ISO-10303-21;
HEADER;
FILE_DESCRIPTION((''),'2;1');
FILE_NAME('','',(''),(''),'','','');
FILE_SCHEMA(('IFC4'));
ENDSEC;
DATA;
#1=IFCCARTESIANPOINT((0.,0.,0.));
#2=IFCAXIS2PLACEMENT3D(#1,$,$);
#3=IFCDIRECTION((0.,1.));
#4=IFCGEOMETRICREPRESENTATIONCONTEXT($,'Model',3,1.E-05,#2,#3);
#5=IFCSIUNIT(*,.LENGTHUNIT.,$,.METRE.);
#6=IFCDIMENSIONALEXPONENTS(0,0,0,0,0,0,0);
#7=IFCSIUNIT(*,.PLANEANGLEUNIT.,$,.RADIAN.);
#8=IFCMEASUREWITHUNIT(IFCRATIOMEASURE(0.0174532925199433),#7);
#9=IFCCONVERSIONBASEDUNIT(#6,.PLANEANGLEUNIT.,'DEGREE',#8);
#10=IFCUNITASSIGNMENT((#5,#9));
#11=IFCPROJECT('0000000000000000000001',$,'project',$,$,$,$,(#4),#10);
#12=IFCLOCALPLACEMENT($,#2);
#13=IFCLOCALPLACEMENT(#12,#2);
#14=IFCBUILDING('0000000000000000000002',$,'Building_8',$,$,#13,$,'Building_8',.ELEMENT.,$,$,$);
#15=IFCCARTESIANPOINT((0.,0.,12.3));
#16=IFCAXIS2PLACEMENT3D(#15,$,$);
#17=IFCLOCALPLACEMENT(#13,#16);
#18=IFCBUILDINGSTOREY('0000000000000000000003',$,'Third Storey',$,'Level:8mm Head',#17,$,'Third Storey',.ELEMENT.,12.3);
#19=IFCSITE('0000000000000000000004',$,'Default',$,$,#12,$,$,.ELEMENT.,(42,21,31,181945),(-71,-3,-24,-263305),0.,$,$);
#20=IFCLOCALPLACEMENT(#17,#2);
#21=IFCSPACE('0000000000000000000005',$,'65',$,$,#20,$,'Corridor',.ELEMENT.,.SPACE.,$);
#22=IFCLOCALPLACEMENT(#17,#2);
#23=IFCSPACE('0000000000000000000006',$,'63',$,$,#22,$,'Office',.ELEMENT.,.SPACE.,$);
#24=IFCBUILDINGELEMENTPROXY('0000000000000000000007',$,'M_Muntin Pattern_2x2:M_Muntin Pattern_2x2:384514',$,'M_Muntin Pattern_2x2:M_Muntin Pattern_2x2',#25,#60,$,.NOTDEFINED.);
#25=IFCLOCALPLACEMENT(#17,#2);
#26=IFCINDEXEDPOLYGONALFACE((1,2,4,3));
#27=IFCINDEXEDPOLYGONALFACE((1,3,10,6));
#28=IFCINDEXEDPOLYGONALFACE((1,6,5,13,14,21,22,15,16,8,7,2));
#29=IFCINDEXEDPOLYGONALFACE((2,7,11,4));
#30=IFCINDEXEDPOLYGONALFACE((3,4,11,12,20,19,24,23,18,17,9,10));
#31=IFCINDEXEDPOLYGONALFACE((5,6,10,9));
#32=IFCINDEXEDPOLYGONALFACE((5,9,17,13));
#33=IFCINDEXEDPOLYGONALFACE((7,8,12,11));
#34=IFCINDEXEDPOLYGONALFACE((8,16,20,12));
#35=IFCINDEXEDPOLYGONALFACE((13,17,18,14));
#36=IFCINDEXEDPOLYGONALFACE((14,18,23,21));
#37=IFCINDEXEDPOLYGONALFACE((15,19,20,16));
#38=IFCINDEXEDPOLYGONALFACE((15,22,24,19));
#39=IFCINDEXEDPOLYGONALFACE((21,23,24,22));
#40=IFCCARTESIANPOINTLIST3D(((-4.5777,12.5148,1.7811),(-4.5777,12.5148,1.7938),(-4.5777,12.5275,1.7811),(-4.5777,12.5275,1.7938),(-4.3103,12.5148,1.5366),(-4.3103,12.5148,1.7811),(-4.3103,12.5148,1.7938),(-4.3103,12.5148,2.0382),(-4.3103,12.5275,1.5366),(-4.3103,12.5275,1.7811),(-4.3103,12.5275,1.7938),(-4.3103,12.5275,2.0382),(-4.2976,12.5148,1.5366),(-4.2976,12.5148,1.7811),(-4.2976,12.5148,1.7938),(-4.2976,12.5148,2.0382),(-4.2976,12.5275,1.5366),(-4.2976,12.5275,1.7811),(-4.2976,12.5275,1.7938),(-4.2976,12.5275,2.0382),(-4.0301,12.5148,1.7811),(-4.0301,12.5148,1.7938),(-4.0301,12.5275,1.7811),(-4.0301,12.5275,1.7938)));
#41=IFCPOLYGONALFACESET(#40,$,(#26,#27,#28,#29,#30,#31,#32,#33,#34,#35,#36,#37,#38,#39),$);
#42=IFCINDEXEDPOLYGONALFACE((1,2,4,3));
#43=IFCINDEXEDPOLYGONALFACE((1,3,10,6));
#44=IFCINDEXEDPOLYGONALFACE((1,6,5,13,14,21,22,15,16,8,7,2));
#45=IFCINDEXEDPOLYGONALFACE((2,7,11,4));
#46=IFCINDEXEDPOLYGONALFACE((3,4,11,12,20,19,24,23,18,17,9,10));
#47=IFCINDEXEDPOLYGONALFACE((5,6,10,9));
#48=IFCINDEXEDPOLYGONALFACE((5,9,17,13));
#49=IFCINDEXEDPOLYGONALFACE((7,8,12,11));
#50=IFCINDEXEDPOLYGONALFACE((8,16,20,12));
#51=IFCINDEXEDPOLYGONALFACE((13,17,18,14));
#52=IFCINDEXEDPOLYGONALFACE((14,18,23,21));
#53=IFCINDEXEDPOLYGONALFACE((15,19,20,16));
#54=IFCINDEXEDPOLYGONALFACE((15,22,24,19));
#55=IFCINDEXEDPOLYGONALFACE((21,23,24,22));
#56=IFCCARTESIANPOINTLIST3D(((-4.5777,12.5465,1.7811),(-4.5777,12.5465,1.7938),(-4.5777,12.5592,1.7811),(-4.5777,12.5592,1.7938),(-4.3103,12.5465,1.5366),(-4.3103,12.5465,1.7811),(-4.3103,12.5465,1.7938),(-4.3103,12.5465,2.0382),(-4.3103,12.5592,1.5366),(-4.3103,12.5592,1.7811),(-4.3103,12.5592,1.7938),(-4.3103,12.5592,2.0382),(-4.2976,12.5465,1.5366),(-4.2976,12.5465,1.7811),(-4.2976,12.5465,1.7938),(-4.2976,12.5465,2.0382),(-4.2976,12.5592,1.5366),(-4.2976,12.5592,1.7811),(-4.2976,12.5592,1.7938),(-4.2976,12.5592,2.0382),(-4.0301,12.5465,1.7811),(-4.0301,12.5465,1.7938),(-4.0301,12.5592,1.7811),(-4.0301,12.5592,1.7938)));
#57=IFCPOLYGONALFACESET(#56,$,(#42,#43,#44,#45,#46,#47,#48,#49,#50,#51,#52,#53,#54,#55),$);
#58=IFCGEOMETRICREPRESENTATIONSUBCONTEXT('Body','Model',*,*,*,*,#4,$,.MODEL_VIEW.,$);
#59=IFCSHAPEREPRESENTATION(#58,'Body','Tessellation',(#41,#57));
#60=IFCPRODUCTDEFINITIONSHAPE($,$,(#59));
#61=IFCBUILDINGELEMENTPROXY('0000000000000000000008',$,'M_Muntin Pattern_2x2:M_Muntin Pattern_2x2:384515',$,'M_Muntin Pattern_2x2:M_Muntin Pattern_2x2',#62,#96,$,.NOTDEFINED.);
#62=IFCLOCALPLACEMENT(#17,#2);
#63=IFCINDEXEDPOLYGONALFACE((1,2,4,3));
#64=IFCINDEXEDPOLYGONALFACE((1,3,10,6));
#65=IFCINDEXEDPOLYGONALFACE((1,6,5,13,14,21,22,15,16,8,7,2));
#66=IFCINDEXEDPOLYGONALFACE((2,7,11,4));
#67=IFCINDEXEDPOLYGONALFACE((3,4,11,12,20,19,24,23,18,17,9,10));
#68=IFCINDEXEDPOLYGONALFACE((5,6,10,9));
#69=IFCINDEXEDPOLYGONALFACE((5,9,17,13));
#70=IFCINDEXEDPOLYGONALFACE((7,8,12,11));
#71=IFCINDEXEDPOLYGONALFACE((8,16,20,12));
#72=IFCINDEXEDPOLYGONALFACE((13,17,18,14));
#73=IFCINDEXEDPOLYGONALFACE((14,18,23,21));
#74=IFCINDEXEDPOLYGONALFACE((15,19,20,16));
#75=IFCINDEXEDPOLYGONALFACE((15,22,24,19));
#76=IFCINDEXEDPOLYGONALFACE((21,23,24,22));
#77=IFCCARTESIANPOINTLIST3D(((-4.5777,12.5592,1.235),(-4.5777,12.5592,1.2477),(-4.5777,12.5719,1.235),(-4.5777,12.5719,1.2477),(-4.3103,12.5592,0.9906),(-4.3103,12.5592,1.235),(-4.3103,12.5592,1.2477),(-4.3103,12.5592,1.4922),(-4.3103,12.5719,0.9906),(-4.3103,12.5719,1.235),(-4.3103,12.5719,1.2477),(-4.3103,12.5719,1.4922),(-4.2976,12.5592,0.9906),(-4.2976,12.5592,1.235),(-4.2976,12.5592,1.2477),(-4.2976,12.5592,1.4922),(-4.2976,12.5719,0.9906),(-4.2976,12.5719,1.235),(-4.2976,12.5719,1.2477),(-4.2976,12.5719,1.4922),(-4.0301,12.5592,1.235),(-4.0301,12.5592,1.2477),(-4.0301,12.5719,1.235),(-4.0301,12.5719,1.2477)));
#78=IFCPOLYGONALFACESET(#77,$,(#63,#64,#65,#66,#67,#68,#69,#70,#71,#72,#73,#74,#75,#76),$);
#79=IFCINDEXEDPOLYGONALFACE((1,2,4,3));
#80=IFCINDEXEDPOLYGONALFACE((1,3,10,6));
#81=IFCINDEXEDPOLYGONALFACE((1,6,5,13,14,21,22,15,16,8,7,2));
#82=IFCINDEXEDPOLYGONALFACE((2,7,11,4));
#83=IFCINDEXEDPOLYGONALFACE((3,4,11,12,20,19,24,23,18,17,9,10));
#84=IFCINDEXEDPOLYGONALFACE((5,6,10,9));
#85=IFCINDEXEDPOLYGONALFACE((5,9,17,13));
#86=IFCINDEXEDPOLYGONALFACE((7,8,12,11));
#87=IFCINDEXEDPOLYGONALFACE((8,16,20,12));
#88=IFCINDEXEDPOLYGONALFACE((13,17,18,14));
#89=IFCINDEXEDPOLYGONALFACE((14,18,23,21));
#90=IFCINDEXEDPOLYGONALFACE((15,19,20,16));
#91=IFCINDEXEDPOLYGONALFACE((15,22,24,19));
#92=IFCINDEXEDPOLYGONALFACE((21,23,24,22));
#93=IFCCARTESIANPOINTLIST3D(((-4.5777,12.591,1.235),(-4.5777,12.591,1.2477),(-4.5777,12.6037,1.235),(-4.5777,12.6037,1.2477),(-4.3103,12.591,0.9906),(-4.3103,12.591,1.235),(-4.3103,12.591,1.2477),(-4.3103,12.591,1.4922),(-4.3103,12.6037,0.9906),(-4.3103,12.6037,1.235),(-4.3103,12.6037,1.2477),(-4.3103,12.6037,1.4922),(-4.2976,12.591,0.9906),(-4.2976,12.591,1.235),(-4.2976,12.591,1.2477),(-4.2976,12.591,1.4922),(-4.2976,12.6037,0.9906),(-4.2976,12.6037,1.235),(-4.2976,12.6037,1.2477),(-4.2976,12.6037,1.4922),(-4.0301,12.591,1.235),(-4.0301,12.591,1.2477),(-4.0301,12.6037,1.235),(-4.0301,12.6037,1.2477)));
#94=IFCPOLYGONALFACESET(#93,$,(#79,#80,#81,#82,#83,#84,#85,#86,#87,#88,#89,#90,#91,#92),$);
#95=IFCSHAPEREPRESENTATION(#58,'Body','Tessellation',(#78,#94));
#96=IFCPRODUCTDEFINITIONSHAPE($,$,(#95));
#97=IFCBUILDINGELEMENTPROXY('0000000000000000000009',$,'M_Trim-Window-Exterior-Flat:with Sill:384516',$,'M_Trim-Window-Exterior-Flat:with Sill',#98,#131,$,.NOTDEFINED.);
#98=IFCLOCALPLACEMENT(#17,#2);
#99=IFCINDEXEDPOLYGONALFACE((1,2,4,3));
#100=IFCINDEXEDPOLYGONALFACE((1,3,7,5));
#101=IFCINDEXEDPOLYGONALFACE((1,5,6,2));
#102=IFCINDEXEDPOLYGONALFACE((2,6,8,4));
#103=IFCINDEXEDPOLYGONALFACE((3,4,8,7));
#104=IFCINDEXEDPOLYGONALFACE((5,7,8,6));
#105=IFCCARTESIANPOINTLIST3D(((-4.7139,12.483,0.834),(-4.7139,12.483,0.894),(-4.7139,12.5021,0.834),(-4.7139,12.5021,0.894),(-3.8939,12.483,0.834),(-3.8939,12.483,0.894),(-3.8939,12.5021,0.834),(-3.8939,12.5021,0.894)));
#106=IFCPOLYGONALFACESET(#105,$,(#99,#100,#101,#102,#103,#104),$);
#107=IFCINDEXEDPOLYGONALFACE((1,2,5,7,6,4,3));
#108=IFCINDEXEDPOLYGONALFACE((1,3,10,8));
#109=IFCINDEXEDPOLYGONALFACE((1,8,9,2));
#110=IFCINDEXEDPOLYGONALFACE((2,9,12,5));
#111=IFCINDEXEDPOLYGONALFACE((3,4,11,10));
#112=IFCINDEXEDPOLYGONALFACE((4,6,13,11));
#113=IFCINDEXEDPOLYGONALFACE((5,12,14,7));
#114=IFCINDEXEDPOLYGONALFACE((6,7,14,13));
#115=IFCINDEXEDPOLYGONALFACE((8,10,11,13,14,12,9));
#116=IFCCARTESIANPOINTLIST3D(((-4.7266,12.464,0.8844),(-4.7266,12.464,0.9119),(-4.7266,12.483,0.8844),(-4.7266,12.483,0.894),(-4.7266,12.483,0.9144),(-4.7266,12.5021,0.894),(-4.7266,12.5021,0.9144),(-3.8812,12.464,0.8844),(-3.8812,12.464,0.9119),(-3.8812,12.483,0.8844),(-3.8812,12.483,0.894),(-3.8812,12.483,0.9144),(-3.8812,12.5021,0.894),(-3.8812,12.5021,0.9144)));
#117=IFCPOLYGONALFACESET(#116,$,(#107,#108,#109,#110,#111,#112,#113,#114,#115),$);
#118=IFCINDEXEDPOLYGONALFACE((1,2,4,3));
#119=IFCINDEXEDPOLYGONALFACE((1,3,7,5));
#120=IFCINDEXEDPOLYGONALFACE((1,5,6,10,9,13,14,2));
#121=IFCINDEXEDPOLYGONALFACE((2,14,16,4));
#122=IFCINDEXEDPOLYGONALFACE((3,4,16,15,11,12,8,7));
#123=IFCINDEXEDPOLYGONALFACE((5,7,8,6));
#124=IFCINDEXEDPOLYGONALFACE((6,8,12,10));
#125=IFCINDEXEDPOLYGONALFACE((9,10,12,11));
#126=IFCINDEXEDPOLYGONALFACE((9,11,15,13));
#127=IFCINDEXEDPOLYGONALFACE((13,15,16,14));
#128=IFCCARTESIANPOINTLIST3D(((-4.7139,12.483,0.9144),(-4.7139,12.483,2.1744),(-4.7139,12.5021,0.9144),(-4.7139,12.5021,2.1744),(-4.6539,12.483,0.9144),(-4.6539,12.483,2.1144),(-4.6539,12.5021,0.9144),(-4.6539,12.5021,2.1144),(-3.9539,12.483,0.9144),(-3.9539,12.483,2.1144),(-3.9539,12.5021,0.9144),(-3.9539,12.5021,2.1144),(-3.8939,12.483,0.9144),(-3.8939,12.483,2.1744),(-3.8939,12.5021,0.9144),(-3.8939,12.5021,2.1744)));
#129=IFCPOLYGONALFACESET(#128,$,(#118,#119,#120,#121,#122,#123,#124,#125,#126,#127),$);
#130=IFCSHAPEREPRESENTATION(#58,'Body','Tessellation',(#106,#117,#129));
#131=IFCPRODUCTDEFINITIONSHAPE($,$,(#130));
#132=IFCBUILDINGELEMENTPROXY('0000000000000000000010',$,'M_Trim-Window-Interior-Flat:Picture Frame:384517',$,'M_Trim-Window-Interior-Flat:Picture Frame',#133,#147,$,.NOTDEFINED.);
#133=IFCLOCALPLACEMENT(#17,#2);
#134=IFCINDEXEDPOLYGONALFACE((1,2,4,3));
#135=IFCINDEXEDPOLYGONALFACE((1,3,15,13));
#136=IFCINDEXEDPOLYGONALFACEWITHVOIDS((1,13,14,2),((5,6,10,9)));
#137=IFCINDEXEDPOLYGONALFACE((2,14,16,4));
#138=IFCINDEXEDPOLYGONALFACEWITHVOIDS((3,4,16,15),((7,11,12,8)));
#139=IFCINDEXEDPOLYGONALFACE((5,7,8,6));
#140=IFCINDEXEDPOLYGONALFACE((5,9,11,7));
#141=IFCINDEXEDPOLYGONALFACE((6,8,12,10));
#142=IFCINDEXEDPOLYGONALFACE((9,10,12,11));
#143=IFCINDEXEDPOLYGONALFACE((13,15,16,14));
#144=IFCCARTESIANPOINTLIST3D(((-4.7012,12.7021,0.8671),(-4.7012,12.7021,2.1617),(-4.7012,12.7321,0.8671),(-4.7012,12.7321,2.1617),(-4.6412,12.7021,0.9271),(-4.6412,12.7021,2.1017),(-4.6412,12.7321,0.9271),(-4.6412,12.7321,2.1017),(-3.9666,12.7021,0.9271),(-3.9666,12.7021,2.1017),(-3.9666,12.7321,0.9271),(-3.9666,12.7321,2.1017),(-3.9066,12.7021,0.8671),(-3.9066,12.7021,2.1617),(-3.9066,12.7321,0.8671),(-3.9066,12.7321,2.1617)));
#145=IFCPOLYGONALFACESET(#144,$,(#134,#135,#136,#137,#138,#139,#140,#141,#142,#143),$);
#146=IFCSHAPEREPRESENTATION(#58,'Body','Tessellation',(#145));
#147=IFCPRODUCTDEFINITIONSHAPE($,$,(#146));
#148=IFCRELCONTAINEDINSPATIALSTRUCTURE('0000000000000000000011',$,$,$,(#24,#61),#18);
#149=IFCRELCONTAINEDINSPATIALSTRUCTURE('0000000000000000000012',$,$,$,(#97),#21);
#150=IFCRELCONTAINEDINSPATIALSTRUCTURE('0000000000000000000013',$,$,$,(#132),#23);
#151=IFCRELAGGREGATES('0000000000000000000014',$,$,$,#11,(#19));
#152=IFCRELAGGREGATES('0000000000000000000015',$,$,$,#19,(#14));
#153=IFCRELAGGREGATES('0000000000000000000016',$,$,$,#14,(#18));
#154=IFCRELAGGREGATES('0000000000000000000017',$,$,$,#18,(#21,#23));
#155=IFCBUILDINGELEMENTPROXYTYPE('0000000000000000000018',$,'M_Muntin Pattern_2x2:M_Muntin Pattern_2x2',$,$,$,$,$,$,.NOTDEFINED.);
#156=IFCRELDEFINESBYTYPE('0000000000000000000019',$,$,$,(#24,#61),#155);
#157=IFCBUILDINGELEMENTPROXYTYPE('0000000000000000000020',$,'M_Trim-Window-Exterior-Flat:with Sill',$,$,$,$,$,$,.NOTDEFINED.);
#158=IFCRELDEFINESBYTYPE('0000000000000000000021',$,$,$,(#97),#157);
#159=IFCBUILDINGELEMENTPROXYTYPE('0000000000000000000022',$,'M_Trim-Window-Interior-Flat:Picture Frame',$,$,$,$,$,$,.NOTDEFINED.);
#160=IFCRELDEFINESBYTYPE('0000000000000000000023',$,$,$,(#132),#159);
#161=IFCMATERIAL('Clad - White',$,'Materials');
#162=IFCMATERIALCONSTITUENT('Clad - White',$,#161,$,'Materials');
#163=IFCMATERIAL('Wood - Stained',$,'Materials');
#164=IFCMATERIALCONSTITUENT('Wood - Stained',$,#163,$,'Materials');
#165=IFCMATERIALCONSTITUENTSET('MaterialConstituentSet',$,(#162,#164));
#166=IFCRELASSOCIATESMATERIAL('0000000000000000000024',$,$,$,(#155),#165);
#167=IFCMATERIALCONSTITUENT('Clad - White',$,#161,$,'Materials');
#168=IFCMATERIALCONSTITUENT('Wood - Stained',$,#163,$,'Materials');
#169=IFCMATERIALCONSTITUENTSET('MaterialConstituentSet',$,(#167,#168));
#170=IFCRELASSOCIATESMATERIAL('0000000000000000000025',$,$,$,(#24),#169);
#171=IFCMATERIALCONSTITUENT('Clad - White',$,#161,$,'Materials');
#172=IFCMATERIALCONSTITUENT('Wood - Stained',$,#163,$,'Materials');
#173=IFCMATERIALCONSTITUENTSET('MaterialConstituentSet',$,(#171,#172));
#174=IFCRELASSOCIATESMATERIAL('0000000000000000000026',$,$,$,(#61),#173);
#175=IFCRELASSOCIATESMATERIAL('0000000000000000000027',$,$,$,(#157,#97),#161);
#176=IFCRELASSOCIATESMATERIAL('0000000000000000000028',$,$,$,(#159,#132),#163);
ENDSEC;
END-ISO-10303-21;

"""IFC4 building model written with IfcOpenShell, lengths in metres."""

from ifc_helpers import new_model, entity, si_unit, converted_unit, direction, frame, origin, place, context, subcontext, project, spatial, indexed_curve, outline, extrude, source, transform, mapped, material, constituent, constituent_set, type_object, type_shapes, element, save


model = new_model("IFC4")

# Units and contexts
model_context = context("Model", 3, precision=1e-05, world=origin(), true_north=direction((0.0, 1.0)))
body_context = subcontext(model_context, "Body", "Model", "MODEL_VIEW")
ifc_project = project(units=[si_unit("LENGTHUNIT", "METRE"), converted_unit("PLANEANGLEUNIT", "DEGREE", entity("IfcRatioMeasure", 0.0174532925199433), si_unit("PLANEANGLEUNIT", "RADIAN"), dimensions=[0, 0, 0, 0, 0, 0, 0])], contexts=[model_context])

# Site, building, storey
site_placement = place(None, origin())
site = spatial("IfcSite", under=ifc_project, at=site_placement, Name="Default", CompositionType="ELEMENT", RefLatitude=(42, 21, 31, 181945), RefLongitude=(-71, -3, -24, -263305), RefElevation=0.0)
building_placement = place(site_placement, origin())
building = spatial("IfcBuilding", under=site, at=building_placement, Name="Building_8", LongName="Building_8", CompositionType="ELEMENT")
storey_placement = place(building_placement, frame((0.0, 0.0, 12.3)))
storey = spatial("IfcBuildingStorey", under=building, at=storey_placement, Name="Third Storey", ObjectType="Level:8mm Head", LongName="Third Storey", CompositionType="ELEMENT", Elevation=12.3)

# Shared definitions
ifc_material_1 = material(Name="Clad - White", Category="Materials")
ifc_material_2 = material(Name="Wood - Stained", Category="Materials")

# Shared definitions
space_1_placement = place(storey_placement, origin())
space_1 = spatial("IfcSpace", under=storey, at=space_1_placement, Name="65", LongName="Corridor", CompositionType="ELEMENT", PredefinedType="SPACE")

# Building element proxies
ifc_constituent_1 = constituent(ifc_material_1, Name="Clad - White", Category="Materials")
ifc_constituent_2 = constituent(ifc_material_2, Name="Wood - Stained", Category="Materials")
ifc_constituent_set_1 = constituent_set(constituents=[ifc_constituent_1, ifc_constituent_2], Name="MaterialConstituentSet")
ifc_constituent_3 = constituent(ifc_material_1, Name="Clad - White", Category="Materials")
ifc_constituent_4 = constituent(ifc_material_2, Name="Wood - Stained", Category="Materials")
ifc_constituent_set_2 = constituent_set(constituents=[ifc_constituent_3, ifc_constituent_4], Name="MaterialConstituentSet")
building_element_proxy_type_1 = type_object("IfcBuildingElementProxyType", Name="M_Muntin Pattern_2x2:M_Muntin Pattern_2x2", PredefinedType="NOTDEFINED", material=ifc_constituent_set_2)
shared_shape_1 = source(origin(), body_context, "Body", "SweptSolid", [
    extrude(outline(indexed_curve([(0.0064, -0.0064), (0.2508, -0.0064), (0.2508, 0.0063), (0.0064, 0.0063), (0.0064, 0.2738), (-0.0063, 0.2738), (-0.0063, 0.0063), (-0.2508, 0.0063), (-0.2508, -0.0064), (-0.0063, -0.0064), (-0.0063, -0.2738), (0.0064, -0.2738), (0.0064, -0.0064)], self_intersect=False)), frame((0.0, 0.0095, 0.2508), z_axis=(0.0, 1.0, 0.0), x_axis=(0.0, 0.0, 1.0)), (0.0, 0.0, 1.0), 0.0127),
    extrude(outline(indexed_curve([(0.0064, -0.0064), (0.2508, -0.0064), (0.2508, 0.0063), (0.0064, 0.0063), (0.0064, 0.2738), (-0.0063, 0.2738), (-0.0063, 0.0063), (-0.2508, 0.0063), (-0.2508, -0.0064), (-0.0063, -0.0064), (-0.0063, -0.2738), (0.0064, -0.2738), (0.0064, -0.0064)], self_intersect=False)), frame((0.0, -0.0222, 0.2508), z_axis=(0.0, 1.0, 0.0), x_axis=(0.0, 0.0, 1.0)), (0.0, 0.0, 1.0), 0.0127),
])
type_shapes(building_element_proxy_type_1, [shared_shape_1])
proxy_1_placement = place(storey_placement, frame((-4.3039, 12.537, 1.5366), z_axis=(0.0, 0.0, 1.0), x_axis=(-1.0, 0.0, 0.0)))
element("IfcBuildingElementProxy", 1, at=proxy_1_placement, inside=storey, type_object=building_element_proxy_type_1, material=ifc_constituent_set_1, Name="M_Muntin Pattern_2x2:M_Muntin Pattern_2x2:384514", ObjectType="M_Muntin Pattern_2x2:M_Muntin Pattern_2x2", PredefinedType="NOTDEFINED", context=body_context, shape_type="MappedRepresentation", body=[
    mapped(shared_shape_1, transform((0.0, 0.0, 0.0), scale=1.0)),
])
ifc_constituent_5 = constituent(ifc_material_1, Name="Clad - White", Category="Materials")
ifc_constituent_6 = constituent(ifc_material_2, Name="Wood - Stained", Category="Materials")
ifc_constituent_set_3 = constituent_set(constituents=[ifc_constituent_5, ifc_constituent_6], Name="MaterialConstituentSet")
proxy_2_placement = place(storey_placement, frame((-4.3039, 12.5814, 0.9906), z_axis=(0.0, 0.0, 1.0), x_axis=(-1.0, 0.0, 0.0)))
element("IfcBuildingElementProxy", 2, at=proxy_2_placement, inside=storey, type_object=building_element_proxy_type_1, material=ifc_constituent_set_3, Name="M_Muntin Pattern_2x2:M_Muntin Pattern_2x2:384515", ObjectType="M_Muntin Pattern_2x2:M_Muntin Pattern_2x2", PredefinedType="NOTDEFINED", context=body_context, shape_type="MappedRepresentation", body=[
    mapped(shared_shape_1, transform((0.0, 0.0, 0.0), scale=1.0)),
])
building_element_proxy_type_2 = type_object("IfcBuildingElementProxyType", Name="M_Trim-Window-Exterior-Flat:with Sill", PredefinedType="NOTDEFINED", material=ifc_material_1)
shared_shape_2 = source(origin(), body_context, "Body", "SweptSolid", [
    extrude(outline(indexed_curve([(-0.41, -0.03), (0.41, -0.03), (0.41, 0.03), (-0.41, 0.03), (-0.41, -0.03)], self_intersect=False)), frame((0.0, -1.2504, 0.0), z_axis=(0.0, 0.0, 1.0), x_axis=(-1.0, 0.0, 0.0)), (0.0, 0.0, 1.0), 0.0191),
    extrude(outline(indexed_curve([(-0.019, -0.0152), (0.0, -0.0152), (0.0, -0.0057), (0.019, -0.0057), (0.019, 0.0148), (0.0, 0.0148), (-0.019, 0.0123), (-0.019, -0.0152)], self_intersect=False)), frame((-0.4227, -1.2148, 0.019), z_axis=(1.0, 0.0, 0.0), x_axis=(0.0, 0.0, -1.0)), (0.0, 0.0, 1.0), 0.8454),
    extrude(outline(indexed_curve([(-0.645, -0.41), (0.615, -0.41), (0.615, -0.35), (-0.585, -0.35), (-0.585, 0.35), (0.615, 0.35), (0.615, 0.41), (-0.645, 0.41), (-0.645, -0.41)], self_intersect=False)), frame((0.0, -0.585, 0.0), z_axis=(0.0, 0.0, 1.0), x_axis=(0.0, -1.0, 0.0)), (0.0, 0.0, 1.0), 0.0191),
])
type_shapes(building_element_proxy_type_2, [shared_shape_2])
proxy_3_placement = place(space_1_placement, frame((-4.3039, 12.5021, 2.1144), z_axis=(0.0, -1.0, 0.0), x_axis=(1.0, 0.0, 0.0)))
element("IfcBuildingElementProxy", 3, at=proxy_3_placement, inside=space_1, type_object=building_element_proxy_type_2, material=ifc_material_1, Name="M_Trim-Window-Exterior-Flat:with Sill:384516", ObjectType="M_Trim-Window-Exterior-Flat:with Sill", PredefinedType="NOTDEFINED", context=body_context, shape_type="MappedRepresentation", body=[
    mapped(shared_shape_2, transform((0.0, 0.0, 0.0), scale=1.0)),
])

# Shared definitions
space_2_placement = place(storey_placement, origin())
space_2 = spatial("IfcSpace", under=storey, at=space_2_placement, Name="63", LongName="Office", CompositionType="ELEMENT", PredefinedType="SPACE")

# Building element proxy
building_element_proxy_type_3 = type_object("IfcBuildingElementProxyType", Name="M_Trim-Window-Interior-Flat:Picture Frame", PredefinedType="NOTDEFINED", material=ifc_material_2)
shared_shape_3 = source(origin(), body_context, "Body", "SweptSolid", [
    extrude(outline(indexed_curve([(-0.3973, -0.6473), (0.3973, -0.6473), (0.3973, 0.6473), (-0.3973, 0.6473), (-0.3973, -0.6473)], self_intersect=False), holes=[indexed_curve([(-0.3373, -0.5873), (-0.3373, 0.5873), (0.3373, 0.5873), (0.3373, -0.5873), (-0.3373, -0.5873)], self_intersect=False)]), frame((0.0, -0.6, 0.0), z_axis=(0.0, 0.0, 1.0), x_axis=(-1.0, 0.0, 0.0)), (0.0, 0.0, 1.0), 0.03),
])
type_shapes(building_element_proxy_type_3, [shared_shape_3])
proxy_4_placement = place(space_2_placement, frame((-4.3039, 12.7021, 2.1144), z_axis=(0.0, 1.0, 0.0), x_axis=(-1.0, 0.0, 0.0)))
element("IfcBuildingElementProxy", 4, at=proxy_4_placement, inside=space_2, type_object=building_element_proxy_type_3, material=ifc_material_2, Name="M_Trim-Window-Interior-Flat:Picture Frame:384517", ObjectType="M_Trim-Window-Interior-Flat:Picture Frame", PredefinedType="NOTDEFINED", context=body_context, shape_type="MappedRepresentation", body=[
    mapped(shared_shape_3, transform((0.0, 0.0, 0.0), scale=1.0)),
])

save(model, "model.ifc")
